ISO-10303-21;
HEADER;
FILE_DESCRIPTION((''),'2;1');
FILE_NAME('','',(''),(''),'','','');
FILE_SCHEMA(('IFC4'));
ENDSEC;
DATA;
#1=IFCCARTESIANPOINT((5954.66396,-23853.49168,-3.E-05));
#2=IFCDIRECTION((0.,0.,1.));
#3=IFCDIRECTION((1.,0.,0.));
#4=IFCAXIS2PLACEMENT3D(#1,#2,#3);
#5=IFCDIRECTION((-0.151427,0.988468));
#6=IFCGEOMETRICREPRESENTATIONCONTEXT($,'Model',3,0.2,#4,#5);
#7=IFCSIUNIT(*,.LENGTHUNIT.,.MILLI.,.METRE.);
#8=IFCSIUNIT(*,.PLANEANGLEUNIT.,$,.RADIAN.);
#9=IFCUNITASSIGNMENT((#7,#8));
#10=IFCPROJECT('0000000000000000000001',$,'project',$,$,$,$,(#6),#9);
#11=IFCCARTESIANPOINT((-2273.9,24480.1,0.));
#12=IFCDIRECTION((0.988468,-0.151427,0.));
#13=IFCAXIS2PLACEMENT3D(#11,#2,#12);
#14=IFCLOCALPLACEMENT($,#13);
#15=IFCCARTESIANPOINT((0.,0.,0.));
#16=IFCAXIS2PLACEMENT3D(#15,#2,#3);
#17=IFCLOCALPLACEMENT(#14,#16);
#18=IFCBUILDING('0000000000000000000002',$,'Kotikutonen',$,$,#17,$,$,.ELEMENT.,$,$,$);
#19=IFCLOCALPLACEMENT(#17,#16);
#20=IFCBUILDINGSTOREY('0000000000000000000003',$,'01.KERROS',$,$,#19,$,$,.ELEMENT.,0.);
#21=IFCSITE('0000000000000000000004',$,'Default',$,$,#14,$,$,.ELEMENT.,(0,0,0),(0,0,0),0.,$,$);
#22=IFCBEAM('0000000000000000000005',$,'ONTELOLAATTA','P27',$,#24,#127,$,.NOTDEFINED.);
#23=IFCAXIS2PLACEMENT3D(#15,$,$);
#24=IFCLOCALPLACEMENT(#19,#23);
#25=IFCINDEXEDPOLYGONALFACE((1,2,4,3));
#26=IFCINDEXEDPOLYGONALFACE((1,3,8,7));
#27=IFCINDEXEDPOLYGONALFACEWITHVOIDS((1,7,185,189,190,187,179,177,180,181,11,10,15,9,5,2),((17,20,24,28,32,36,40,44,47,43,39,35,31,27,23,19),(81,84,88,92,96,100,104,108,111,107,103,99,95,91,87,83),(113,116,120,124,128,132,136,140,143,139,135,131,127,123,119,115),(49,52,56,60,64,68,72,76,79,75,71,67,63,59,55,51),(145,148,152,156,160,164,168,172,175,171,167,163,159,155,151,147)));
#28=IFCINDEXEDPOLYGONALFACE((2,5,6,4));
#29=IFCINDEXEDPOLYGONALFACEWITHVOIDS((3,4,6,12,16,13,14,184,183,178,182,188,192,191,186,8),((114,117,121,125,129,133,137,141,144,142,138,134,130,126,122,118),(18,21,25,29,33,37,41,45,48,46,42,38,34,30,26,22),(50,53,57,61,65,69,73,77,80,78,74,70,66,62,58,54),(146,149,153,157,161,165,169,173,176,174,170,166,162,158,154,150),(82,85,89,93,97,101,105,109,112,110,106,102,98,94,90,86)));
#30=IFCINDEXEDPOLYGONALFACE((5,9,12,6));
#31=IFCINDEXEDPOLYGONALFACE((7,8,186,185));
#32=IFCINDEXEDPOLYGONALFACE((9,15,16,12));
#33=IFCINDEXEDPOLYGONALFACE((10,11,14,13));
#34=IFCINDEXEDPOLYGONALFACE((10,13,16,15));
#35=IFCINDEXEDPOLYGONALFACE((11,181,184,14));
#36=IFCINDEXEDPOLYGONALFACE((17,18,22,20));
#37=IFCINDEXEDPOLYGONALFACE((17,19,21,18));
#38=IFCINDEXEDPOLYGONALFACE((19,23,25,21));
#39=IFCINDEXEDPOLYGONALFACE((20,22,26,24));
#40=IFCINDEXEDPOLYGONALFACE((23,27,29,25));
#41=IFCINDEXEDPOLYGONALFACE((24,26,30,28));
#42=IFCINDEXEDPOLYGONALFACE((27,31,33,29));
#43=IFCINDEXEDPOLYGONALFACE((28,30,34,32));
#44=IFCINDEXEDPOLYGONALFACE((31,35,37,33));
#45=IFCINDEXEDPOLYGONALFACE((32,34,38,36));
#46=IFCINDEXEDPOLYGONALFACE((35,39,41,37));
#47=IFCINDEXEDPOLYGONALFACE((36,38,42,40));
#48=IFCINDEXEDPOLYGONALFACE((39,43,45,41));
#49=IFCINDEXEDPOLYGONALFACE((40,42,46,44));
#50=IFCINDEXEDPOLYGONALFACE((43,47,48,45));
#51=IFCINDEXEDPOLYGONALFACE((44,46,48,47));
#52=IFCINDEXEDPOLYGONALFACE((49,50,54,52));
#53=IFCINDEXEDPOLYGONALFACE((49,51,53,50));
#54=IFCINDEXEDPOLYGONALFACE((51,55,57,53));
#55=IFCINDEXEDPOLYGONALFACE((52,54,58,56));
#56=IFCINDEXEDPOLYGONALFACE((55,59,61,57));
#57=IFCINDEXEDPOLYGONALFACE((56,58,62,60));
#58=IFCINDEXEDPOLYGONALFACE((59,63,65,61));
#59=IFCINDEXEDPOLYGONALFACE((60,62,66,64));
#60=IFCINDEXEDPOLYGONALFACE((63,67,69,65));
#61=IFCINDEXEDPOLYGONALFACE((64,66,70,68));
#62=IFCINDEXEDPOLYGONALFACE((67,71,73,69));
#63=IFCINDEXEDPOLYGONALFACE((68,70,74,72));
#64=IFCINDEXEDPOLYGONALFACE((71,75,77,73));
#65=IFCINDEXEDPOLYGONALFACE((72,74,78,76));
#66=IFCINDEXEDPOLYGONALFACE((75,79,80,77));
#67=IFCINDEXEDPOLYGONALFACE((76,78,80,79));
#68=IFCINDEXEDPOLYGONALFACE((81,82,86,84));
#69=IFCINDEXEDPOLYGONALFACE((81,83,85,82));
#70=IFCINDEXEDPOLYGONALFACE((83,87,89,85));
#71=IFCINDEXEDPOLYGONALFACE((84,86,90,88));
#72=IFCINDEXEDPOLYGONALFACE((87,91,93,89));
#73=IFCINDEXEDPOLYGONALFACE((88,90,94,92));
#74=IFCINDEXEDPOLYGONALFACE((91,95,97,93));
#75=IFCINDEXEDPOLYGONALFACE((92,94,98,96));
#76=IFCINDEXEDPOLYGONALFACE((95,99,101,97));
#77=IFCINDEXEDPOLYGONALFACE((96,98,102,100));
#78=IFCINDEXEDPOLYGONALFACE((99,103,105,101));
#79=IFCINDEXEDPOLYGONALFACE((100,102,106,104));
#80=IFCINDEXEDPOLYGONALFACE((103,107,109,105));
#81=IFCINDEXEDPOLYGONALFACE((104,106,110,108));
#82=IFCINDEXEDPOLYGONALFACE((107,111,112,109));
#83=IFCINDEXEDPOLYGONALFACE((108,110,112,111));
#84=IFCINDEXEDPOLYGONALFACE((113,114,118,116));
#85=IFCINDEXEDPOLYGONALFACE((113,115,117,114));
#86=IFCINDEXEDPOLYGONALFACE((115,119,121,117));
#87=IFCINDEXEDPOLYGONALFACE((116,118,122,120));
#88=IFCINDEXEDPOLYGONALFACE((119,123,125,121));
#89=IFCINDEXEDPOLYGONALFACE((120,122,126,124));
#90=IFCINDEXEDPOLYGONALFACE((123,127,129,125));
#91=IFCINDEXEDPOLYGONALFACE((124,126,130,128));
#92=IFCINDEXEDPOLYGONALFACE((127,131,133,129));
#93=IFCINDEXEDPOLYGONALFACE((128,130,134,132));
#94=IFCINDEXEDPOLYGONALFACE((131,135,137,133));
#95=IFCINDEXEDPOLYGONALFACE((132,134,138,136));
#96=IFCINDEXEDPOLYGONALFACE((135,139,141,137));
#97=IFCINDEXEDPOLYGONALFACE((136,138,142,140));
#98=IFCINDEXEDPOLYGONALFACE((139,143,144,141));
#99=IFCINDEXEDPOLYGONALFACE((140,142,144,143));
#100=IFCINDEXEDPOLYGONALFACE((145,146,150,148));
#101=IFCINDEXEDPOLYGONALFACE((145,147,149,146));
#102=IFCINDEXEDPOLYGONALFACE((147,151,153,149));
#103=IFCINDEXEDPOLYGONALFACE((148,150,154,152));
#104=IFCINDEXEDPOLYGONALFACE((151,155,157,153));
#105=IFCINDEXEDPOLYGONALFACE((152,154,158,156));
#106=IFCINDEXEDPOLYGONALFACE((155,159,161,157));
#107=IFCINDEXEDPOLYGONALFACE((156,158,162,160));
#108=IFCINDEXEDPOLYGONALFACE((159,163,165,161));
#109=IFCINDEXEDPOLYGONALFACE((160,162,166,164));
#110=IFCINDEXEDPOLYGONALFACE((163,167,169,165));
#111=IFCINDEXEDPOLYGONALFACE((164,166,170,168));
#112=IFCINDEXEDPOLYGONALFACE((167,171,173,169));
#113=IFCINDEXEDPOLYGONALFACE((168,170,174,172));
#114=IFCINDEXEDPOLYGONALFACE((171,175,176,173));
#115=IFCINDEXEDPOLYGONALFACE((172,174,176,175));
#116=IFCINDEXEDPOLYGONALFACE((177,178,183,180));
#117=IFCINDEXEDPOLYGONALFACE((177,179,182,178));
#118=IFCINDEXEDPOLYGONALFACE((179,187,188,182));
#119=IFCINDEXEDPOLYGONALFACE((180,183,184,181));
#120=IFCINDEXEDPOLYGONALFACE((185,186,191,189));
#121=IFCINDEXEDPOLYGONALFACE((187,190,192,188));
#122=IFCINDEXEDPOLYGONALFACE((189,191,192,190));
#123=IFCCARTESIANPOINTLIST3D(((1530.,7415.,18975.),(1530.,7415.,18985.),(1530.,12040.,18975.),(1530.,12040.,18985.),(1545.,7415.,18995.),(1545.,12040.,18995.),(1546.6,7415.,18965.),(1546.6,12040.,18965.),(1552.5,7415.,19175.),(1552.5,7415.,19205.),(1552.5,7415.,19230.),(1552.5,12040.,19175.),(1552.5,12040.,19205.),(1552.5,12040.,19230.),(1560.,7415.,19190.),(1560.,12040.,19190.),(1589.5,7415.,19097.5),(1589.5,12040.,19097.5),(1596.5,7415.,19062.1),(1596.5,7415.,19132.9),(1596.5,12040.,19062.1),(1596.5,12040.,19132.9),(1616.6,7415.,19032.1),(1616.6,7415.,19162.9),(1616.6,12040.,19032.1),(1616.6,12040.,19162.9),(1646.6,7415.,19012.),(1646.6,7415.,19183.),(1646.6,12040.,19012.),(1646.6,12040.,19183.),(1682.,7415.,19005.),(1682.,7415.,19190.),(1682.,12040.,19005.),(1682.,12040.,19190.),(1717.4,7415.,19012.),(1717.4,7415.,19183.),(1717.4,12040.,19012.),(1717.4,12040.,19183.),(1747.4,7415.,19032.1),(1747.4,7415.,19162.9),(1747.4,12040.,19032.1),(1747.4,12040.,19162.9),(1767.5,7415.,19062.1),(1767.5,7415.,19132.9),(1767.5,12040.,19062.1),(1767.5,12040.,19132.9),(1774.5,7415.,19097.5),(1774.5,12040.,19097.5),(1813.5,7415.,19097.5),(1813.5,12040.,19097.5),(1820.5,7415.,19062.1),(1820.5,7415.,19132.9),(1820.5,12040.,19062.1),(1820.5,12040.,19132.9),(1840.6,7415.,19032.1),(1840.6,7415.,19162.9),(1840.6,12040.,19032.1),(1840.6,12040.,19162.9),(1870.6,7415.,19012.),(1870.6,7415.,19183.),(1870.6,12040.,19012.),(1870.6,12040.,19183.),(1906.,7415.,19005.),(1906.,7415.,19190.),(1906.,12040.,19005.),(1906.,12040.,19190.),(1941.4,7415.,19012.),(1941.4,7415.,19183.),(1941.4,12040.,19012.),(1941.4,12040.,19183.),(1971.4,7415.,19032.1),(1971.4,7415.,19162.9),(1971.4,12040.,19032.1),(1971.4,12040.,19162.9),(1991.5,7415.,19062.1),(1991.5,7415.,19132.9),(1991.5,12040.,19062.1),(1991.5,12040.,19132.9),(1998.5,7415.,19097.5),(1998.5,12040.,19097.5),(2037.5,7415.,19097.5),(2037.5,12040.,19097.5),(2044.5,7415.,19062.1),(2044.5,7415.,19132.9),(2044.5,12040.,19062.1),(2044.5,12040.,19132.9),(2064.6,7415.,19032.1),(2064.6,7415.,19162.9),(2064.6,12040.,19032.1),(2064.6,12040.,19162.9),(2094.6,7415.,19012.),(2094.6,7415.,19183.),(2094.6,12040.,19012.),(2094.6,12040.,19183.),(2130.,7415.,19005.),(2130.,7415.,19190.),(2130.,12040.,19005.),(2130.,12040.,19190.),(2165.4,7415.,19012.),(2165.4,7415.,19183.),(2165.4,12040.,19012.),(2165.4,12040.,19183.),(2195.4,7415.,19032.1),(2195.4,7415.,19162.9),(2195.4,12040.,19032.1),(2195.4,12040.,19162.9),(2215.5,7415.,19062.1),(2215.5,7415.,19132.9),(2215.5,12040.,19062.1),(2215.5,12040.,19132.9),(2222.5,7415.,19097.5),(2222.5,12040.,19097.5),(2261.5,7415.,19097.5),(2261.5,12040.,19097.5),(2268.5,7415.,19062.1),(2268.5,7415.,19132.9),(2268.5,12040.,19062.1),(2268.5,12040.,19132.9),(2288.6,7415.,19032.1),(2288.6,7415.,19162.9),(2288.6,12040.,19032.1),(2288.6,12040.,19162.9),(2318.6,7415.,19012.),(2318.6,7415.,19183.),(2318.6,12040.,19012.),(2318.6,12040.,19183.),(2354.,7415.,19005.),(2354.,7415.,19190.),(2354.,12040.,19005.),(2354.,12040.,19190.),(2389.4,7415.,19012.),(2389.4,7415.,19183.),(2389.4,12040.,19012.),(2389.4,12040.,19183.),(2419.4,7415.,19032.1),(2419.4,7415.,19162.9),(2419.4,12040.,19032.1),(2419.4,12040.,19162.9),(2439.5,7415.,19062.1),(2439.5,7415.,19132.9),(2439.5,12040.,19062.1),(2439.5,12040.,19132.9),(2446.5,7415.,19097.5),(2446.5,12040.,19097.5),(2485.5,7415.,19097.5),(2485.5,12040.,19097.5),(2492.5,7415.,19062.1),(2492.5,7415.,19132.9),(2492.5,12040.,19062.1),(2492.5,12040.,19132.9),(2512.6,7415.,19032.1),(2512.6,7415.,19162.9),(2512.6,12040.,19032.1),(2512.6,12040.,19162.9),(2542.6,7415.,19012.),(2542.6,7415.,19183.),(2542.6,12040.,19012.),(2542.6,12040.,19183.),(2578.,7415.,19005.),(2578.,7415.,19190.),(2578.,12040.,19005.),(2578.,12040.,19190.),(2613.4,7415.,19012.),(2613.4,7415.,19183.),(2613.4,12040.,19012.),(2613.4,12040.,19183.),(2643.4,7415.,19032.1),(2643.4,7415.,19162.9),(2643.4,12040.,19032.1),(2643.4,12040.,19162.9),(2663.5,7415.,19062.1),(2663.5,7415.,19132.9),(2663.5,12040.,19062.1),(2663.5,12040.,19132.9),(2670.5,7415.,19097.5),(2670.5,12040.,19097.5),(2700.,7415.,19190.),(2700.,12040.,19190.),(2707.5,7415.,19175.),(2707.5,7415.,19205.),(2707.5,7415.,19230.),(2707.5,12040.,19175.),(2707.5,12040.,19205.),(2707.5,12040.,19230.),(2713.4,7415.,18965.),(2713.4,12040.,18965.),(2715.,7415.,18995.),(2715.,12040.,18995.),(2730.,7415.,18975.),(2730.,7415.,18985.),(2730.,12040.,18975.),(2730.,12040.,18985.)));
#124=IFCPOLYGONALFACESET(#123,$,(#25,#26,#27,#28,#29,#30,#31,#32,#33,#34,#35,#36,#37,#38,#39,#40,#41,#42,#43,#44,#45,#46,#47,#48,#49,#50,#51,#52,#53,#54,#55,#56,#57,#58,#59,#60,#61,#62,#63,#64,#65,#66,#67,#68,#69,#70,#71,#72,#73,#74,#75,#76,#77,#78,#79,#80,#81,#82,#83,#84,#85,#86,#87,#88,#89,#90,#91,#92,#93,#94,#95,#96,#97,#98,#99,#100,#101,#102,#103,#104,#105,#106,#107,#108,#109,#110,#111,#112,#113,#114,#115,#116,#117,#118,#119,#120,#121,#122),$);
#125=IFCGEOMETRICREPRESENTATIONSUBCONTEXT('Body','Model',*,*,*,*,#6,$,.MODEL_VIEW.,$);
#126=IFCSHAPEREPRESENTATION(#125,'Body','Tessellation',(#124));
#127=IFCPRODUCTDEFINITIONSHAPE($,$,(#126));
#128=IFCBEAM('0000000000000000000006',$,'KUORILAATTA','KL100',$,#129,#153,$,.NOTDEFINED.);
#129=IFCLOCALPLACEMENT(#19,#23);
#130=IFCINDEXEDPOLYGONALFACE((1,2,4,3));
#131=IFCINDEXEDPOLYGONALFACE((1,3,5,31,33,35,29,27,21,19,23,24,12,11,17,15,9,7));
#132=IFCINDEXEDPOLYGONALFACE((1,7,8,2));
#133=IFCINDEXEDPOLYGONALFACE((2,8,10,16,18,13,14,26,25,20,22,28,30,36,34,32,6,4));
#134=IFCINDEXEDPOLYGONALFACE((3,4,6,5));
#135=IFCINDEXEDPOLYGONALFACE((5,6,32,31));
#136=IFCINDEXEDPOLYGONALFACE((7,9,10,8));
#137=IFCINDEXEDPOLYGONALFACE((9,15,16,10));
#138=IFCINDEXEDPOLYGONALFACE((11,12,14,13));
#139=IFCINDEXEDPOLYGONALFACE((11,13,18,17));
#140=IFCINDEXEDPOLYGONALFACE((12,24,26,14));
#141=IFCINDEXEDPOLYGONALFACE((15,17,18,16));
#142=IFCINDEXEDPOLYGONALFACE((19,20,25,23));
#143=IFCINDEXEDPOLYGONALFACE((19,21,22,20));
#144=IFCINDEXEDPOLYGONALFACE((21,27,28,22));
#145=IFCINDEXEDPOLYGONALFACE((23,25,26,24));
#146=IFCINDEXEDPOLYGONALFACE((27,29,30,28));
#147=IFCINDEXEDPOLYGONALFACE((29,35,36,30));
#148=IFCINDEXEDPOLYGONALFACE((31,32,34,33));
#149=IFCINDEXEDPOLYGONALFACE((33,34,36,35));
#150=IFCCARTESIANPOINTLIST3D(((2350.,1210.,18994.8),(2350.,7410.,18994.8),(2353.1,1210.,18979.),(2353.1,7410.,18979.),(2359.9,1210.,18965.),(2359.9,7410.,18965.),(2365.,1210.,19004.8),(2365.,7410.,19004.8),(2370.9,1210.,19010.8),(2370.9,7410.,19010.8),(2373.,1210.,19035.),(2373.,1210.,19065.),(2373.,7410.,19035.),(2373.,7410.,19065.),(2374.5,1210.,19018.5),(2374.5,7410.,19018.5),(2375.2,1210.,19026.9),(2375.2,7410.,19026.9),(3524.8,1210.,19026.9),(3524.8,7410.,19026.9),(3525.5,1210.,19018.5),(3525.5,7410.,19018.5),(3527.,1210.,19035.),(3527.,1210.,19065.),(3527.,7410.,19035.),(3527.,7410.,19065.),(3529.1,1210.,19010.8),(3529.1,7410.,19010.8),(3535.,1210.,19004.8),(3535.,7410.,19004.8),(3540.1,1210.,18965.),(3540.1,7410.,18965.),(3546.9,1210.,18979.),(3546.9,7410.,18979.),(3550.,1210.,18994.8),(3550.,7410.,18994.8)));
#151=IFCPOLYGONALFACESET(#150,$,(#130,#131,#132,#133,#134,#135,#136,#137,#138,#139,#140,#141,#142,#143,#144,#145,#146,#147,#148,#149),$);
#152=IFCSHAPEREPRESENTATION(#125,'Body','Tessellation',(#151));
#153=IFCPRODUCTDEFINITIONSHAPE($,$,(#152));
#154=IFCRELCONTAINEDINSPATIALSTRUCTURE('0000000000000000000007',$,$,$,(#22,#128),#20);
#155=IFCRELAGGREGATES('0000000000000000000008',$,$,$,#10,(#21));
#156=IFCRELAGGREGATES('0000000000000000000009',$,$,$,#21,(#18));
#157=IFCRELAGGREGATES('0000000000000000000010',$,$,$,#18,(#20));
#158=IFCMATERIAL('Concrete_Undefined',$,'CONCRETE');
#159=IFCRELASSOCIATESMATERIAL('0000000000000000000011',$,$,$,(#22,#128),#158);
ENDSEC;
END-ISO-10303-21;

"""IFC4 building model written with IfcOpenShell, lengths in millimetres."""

from ifc_helpers import new_model, si_unit, direction, frame, origin_with_axes, place, context, subcontext, project, spatial, line, indexed_curve, outline, extrude, material, element, save


model = new_model("IFC4")

# Units and contexts
model_context = context("Model", 3, precision=0.2, world=frame((5954.66396, -23853.49168, -3e-05), z_axis=(0.0, 0.0, 1.0), x_axis=(1.0, 0.0, 0.0)), true_north=direction((-0.151427, 0.988468)))
body_context = subcontext(model_context, "Body", "Model", "MODEL_VIEW")
ifc_project = project(units=[si_unit("LENGTHUNIT", "METRE", prefix="MILLI"), si_unit("PLANEANGLEUNIT", "RADIAN")], contexts=[model_context])

# Site, building, storey
site_placement = place(None, frame((-2273.9, 24480.1, 0.0), z_axis=(0.0, 0.0, 1.0), x_axis=(0.988468, -0.151427, 0.0)))
site = spatial("IfcSite", under=ifc_project, at=site_placement, Name="Default", CompositionType="ELEMENT", RefLatitude=(0, 0, 0), RefLongitude=(0, 0, 0), RefElevation=0.0)
building_placement = place(site_placement, origin_with_axes())
building = spatial("IfcBuilding", under=site, at=building_placement, Name="Kotikutonen", CompositionType="ELEMENT")
storey_placement = place(building_placement, origin_with_axes())
storey = spatial("IfcBuildingStorey", under=building, at=storey_placement, Name="01.KERROS", CompositionType="ELEMENT", Elevation=0.0)

# Shared definitions
ifc_material_1 = material(Name="Concrete_Undefined", Category="CONCRETE")

# Beams
beam_1_placement = place(storey_placement, frame((2130.0, 12040.0, 19097.5), z_axis=(-1.0, 0.0, 0.0), x_axis=(0.0, -1.0, 0.0)))
element("IfcBeam", 1, at=beam_1_placement, inside=storey, material=ifc_material_1, Name="ONTELOLAATTA", Description="P27", PredefinedType="NOTDEFINED", context=body_context, shape_type="SolidModel", body=[
    extrude(outline(indexed_curve([(-600.0, -122.5), (-583.4, -132.5), (583.4, -132.5), (600.0, -122.5), (600.0, -112.5), (585.0, -102.5), (577.5, 77.5), (570.0, 92.5), (577.5, 107.5), (577.5, 132.5), (-577.5, 132.5), (-577.5, 107.5), (-570.0, 92.5), (-577.5, 77.5), (-585.0, -102.5), (-600.0, -112.5)], segments=[line(1, 2, 3, 4, 5, 6, 7, 8, 9, 10, 11, 12, 13, 14, 15, 16, 1)]), holes=[indexed_curve([(-448.0, -92.5), (-483.4, -85.5), (-513.4, -65.4), (-533.5, -35.4), (-540.5, 0.0), (-533.5, 35.4), (-513.4, 65.4), (-483.4, 85.5), (-448.0, 92.5), (-412.6, 85.5), (-382.6, 65.4), (-362.5, 35.4), (-355.5, 0.0), (-362.5, -35.4), (-382.6, -65.4), (-412.6, -85.5)], segments=[line(1, 2, 3, 4, 5, 6, 7, 8, 9, 10, 11, 12, 13, 14, 15, 16, 1)]), indexed_curve([(-224.0, -92.5), (-259.4, -85.5), (-289.4, -65.4), (-309.5, -35.4), (-316.5, 0.0), (-309.5, 35.4), (-289.4, 65.4), (-259.4, 85.5), (-224.0, 92.5), (-188.6, 85.5), (-158.6, 65.4), (-138.5, 35.4), (-131.5, 0.0), (-138.5, -35.4), (-158.6, -65.4), (-188.6, -85.5)], segments=[line(1, 2, 3, 4, 5, 6, 7, 8, 9, 10, 11, 12, 13, 14, 15, 16, 1)]), indexed_curve([(0.0, -92.5), (-35.4, -85.5), (-65.4, -65.4), (-85.5, -35.4), (-92.5, 0.0), (-85.5, 35.4), (-65.4, 65.4), (-35.4, 85.5), (0.0, 92.5), (35.4, 85.5), (65.4, 65.4), (85.5, 35.4), (92.5, 0.0), (85.5, -35.4), (65.4, -65.4), (35.4, -85.5)], segments=[line(1, 2, 3, 4, 5, 6, 7, 8, 9, 10, 11, 12, 13, 14, 15, 16, 1)]), indexed_curve([(224.0, -92.5), (188.6, -85.5), (158.6, -65.4), (138.5, -35.4), (131.5, 0.0), (138.5, 35.4), (158.6, 65.4), (188.6, 85.5), (224.0, 92.5), (259.4, 85.5), (289.4, 65.4), (309.5, 35.4), (316.5, 0.0), (309.5, -35.4), (289.4, -65.4), (259.4, -85.5)], segments=[line(1, 2, 3, 4, 5, 6, 7, 8, 9, 10, 11, 12, 13, 14, 15, 16, 1)]), indexed_curve([(448.0, -92.5), (412.6, -85.5), (382.6, -65.4), (362.5, -35.4), (355.5, 0.0), (362.5, 35.4), (382.6, 65.4), (412.6, 85.5), (448.0, 92.5), (483.4, 85.5), (513.4, 65.4), (533.5, 35.4), (540.5, 0.0), (533.5, -35.4), (513.4, -65.4), (483.4, -85.5)], segments=[line(1, 2, 3, 4, 5, 6, 7, 8, 9, 10, 11, 12, 13, 14, 15, 16, 1)])]), frame((0.0, 0.0, 0.0), z_axis=(-1.0, 0.0, 0.0), x_axis=(0.0, 0.0, 1.0)), (0.0, 0.0, -1.0), 4625.0),
])
beam_2_placement = place(storey_placement, frame((2950.0, 7410.0, 19015.0), z_axis=(-1.0, 0.0, 0.0), x_axis=(0.0, -1.0, 0.0)))
element("IfcBeam", 2, at=beam_2_placement, inside=storey, material=ifc_material_1, Name="KUORILAATTA", Description="KL100", PredefinedType="NOTDEFINED", context=body_context, shape_type="SolidModel", body=[
    extrude(outline(indexed_curve([(-596.9, -36.0), (-590.1, -50.0), (590.1, -50.0), (596.9, -36.0), (600.0, -20.2), (585.0, -10.2), (579.1, -4.2), (575.5, 3.5), (574.8, 11.9), (577.0, 20.0), (577.0, 50.0), (-577.0, 50.0), (-577.0, 20.0), (-574.8, 11.9), (-575.5, 3.5), (-579.1, -4.2), (-585.0, -10.2), (-600.0, -20.2)], segments=[line(1, 2, 3, 4, 5, 6, 7, 8, 9, 10, 11, 12, 13, 14, 15, 16, 17, 18, 1)])), frame((0.0, 0.0, 0.0), z_axis=(-1.0, 0.0, 0.0), x_axis=(0.0, 0.0, 1.0)), (0.0, 0.0, -1.0), 6200.0),
])

save(model, "model.ifc")
